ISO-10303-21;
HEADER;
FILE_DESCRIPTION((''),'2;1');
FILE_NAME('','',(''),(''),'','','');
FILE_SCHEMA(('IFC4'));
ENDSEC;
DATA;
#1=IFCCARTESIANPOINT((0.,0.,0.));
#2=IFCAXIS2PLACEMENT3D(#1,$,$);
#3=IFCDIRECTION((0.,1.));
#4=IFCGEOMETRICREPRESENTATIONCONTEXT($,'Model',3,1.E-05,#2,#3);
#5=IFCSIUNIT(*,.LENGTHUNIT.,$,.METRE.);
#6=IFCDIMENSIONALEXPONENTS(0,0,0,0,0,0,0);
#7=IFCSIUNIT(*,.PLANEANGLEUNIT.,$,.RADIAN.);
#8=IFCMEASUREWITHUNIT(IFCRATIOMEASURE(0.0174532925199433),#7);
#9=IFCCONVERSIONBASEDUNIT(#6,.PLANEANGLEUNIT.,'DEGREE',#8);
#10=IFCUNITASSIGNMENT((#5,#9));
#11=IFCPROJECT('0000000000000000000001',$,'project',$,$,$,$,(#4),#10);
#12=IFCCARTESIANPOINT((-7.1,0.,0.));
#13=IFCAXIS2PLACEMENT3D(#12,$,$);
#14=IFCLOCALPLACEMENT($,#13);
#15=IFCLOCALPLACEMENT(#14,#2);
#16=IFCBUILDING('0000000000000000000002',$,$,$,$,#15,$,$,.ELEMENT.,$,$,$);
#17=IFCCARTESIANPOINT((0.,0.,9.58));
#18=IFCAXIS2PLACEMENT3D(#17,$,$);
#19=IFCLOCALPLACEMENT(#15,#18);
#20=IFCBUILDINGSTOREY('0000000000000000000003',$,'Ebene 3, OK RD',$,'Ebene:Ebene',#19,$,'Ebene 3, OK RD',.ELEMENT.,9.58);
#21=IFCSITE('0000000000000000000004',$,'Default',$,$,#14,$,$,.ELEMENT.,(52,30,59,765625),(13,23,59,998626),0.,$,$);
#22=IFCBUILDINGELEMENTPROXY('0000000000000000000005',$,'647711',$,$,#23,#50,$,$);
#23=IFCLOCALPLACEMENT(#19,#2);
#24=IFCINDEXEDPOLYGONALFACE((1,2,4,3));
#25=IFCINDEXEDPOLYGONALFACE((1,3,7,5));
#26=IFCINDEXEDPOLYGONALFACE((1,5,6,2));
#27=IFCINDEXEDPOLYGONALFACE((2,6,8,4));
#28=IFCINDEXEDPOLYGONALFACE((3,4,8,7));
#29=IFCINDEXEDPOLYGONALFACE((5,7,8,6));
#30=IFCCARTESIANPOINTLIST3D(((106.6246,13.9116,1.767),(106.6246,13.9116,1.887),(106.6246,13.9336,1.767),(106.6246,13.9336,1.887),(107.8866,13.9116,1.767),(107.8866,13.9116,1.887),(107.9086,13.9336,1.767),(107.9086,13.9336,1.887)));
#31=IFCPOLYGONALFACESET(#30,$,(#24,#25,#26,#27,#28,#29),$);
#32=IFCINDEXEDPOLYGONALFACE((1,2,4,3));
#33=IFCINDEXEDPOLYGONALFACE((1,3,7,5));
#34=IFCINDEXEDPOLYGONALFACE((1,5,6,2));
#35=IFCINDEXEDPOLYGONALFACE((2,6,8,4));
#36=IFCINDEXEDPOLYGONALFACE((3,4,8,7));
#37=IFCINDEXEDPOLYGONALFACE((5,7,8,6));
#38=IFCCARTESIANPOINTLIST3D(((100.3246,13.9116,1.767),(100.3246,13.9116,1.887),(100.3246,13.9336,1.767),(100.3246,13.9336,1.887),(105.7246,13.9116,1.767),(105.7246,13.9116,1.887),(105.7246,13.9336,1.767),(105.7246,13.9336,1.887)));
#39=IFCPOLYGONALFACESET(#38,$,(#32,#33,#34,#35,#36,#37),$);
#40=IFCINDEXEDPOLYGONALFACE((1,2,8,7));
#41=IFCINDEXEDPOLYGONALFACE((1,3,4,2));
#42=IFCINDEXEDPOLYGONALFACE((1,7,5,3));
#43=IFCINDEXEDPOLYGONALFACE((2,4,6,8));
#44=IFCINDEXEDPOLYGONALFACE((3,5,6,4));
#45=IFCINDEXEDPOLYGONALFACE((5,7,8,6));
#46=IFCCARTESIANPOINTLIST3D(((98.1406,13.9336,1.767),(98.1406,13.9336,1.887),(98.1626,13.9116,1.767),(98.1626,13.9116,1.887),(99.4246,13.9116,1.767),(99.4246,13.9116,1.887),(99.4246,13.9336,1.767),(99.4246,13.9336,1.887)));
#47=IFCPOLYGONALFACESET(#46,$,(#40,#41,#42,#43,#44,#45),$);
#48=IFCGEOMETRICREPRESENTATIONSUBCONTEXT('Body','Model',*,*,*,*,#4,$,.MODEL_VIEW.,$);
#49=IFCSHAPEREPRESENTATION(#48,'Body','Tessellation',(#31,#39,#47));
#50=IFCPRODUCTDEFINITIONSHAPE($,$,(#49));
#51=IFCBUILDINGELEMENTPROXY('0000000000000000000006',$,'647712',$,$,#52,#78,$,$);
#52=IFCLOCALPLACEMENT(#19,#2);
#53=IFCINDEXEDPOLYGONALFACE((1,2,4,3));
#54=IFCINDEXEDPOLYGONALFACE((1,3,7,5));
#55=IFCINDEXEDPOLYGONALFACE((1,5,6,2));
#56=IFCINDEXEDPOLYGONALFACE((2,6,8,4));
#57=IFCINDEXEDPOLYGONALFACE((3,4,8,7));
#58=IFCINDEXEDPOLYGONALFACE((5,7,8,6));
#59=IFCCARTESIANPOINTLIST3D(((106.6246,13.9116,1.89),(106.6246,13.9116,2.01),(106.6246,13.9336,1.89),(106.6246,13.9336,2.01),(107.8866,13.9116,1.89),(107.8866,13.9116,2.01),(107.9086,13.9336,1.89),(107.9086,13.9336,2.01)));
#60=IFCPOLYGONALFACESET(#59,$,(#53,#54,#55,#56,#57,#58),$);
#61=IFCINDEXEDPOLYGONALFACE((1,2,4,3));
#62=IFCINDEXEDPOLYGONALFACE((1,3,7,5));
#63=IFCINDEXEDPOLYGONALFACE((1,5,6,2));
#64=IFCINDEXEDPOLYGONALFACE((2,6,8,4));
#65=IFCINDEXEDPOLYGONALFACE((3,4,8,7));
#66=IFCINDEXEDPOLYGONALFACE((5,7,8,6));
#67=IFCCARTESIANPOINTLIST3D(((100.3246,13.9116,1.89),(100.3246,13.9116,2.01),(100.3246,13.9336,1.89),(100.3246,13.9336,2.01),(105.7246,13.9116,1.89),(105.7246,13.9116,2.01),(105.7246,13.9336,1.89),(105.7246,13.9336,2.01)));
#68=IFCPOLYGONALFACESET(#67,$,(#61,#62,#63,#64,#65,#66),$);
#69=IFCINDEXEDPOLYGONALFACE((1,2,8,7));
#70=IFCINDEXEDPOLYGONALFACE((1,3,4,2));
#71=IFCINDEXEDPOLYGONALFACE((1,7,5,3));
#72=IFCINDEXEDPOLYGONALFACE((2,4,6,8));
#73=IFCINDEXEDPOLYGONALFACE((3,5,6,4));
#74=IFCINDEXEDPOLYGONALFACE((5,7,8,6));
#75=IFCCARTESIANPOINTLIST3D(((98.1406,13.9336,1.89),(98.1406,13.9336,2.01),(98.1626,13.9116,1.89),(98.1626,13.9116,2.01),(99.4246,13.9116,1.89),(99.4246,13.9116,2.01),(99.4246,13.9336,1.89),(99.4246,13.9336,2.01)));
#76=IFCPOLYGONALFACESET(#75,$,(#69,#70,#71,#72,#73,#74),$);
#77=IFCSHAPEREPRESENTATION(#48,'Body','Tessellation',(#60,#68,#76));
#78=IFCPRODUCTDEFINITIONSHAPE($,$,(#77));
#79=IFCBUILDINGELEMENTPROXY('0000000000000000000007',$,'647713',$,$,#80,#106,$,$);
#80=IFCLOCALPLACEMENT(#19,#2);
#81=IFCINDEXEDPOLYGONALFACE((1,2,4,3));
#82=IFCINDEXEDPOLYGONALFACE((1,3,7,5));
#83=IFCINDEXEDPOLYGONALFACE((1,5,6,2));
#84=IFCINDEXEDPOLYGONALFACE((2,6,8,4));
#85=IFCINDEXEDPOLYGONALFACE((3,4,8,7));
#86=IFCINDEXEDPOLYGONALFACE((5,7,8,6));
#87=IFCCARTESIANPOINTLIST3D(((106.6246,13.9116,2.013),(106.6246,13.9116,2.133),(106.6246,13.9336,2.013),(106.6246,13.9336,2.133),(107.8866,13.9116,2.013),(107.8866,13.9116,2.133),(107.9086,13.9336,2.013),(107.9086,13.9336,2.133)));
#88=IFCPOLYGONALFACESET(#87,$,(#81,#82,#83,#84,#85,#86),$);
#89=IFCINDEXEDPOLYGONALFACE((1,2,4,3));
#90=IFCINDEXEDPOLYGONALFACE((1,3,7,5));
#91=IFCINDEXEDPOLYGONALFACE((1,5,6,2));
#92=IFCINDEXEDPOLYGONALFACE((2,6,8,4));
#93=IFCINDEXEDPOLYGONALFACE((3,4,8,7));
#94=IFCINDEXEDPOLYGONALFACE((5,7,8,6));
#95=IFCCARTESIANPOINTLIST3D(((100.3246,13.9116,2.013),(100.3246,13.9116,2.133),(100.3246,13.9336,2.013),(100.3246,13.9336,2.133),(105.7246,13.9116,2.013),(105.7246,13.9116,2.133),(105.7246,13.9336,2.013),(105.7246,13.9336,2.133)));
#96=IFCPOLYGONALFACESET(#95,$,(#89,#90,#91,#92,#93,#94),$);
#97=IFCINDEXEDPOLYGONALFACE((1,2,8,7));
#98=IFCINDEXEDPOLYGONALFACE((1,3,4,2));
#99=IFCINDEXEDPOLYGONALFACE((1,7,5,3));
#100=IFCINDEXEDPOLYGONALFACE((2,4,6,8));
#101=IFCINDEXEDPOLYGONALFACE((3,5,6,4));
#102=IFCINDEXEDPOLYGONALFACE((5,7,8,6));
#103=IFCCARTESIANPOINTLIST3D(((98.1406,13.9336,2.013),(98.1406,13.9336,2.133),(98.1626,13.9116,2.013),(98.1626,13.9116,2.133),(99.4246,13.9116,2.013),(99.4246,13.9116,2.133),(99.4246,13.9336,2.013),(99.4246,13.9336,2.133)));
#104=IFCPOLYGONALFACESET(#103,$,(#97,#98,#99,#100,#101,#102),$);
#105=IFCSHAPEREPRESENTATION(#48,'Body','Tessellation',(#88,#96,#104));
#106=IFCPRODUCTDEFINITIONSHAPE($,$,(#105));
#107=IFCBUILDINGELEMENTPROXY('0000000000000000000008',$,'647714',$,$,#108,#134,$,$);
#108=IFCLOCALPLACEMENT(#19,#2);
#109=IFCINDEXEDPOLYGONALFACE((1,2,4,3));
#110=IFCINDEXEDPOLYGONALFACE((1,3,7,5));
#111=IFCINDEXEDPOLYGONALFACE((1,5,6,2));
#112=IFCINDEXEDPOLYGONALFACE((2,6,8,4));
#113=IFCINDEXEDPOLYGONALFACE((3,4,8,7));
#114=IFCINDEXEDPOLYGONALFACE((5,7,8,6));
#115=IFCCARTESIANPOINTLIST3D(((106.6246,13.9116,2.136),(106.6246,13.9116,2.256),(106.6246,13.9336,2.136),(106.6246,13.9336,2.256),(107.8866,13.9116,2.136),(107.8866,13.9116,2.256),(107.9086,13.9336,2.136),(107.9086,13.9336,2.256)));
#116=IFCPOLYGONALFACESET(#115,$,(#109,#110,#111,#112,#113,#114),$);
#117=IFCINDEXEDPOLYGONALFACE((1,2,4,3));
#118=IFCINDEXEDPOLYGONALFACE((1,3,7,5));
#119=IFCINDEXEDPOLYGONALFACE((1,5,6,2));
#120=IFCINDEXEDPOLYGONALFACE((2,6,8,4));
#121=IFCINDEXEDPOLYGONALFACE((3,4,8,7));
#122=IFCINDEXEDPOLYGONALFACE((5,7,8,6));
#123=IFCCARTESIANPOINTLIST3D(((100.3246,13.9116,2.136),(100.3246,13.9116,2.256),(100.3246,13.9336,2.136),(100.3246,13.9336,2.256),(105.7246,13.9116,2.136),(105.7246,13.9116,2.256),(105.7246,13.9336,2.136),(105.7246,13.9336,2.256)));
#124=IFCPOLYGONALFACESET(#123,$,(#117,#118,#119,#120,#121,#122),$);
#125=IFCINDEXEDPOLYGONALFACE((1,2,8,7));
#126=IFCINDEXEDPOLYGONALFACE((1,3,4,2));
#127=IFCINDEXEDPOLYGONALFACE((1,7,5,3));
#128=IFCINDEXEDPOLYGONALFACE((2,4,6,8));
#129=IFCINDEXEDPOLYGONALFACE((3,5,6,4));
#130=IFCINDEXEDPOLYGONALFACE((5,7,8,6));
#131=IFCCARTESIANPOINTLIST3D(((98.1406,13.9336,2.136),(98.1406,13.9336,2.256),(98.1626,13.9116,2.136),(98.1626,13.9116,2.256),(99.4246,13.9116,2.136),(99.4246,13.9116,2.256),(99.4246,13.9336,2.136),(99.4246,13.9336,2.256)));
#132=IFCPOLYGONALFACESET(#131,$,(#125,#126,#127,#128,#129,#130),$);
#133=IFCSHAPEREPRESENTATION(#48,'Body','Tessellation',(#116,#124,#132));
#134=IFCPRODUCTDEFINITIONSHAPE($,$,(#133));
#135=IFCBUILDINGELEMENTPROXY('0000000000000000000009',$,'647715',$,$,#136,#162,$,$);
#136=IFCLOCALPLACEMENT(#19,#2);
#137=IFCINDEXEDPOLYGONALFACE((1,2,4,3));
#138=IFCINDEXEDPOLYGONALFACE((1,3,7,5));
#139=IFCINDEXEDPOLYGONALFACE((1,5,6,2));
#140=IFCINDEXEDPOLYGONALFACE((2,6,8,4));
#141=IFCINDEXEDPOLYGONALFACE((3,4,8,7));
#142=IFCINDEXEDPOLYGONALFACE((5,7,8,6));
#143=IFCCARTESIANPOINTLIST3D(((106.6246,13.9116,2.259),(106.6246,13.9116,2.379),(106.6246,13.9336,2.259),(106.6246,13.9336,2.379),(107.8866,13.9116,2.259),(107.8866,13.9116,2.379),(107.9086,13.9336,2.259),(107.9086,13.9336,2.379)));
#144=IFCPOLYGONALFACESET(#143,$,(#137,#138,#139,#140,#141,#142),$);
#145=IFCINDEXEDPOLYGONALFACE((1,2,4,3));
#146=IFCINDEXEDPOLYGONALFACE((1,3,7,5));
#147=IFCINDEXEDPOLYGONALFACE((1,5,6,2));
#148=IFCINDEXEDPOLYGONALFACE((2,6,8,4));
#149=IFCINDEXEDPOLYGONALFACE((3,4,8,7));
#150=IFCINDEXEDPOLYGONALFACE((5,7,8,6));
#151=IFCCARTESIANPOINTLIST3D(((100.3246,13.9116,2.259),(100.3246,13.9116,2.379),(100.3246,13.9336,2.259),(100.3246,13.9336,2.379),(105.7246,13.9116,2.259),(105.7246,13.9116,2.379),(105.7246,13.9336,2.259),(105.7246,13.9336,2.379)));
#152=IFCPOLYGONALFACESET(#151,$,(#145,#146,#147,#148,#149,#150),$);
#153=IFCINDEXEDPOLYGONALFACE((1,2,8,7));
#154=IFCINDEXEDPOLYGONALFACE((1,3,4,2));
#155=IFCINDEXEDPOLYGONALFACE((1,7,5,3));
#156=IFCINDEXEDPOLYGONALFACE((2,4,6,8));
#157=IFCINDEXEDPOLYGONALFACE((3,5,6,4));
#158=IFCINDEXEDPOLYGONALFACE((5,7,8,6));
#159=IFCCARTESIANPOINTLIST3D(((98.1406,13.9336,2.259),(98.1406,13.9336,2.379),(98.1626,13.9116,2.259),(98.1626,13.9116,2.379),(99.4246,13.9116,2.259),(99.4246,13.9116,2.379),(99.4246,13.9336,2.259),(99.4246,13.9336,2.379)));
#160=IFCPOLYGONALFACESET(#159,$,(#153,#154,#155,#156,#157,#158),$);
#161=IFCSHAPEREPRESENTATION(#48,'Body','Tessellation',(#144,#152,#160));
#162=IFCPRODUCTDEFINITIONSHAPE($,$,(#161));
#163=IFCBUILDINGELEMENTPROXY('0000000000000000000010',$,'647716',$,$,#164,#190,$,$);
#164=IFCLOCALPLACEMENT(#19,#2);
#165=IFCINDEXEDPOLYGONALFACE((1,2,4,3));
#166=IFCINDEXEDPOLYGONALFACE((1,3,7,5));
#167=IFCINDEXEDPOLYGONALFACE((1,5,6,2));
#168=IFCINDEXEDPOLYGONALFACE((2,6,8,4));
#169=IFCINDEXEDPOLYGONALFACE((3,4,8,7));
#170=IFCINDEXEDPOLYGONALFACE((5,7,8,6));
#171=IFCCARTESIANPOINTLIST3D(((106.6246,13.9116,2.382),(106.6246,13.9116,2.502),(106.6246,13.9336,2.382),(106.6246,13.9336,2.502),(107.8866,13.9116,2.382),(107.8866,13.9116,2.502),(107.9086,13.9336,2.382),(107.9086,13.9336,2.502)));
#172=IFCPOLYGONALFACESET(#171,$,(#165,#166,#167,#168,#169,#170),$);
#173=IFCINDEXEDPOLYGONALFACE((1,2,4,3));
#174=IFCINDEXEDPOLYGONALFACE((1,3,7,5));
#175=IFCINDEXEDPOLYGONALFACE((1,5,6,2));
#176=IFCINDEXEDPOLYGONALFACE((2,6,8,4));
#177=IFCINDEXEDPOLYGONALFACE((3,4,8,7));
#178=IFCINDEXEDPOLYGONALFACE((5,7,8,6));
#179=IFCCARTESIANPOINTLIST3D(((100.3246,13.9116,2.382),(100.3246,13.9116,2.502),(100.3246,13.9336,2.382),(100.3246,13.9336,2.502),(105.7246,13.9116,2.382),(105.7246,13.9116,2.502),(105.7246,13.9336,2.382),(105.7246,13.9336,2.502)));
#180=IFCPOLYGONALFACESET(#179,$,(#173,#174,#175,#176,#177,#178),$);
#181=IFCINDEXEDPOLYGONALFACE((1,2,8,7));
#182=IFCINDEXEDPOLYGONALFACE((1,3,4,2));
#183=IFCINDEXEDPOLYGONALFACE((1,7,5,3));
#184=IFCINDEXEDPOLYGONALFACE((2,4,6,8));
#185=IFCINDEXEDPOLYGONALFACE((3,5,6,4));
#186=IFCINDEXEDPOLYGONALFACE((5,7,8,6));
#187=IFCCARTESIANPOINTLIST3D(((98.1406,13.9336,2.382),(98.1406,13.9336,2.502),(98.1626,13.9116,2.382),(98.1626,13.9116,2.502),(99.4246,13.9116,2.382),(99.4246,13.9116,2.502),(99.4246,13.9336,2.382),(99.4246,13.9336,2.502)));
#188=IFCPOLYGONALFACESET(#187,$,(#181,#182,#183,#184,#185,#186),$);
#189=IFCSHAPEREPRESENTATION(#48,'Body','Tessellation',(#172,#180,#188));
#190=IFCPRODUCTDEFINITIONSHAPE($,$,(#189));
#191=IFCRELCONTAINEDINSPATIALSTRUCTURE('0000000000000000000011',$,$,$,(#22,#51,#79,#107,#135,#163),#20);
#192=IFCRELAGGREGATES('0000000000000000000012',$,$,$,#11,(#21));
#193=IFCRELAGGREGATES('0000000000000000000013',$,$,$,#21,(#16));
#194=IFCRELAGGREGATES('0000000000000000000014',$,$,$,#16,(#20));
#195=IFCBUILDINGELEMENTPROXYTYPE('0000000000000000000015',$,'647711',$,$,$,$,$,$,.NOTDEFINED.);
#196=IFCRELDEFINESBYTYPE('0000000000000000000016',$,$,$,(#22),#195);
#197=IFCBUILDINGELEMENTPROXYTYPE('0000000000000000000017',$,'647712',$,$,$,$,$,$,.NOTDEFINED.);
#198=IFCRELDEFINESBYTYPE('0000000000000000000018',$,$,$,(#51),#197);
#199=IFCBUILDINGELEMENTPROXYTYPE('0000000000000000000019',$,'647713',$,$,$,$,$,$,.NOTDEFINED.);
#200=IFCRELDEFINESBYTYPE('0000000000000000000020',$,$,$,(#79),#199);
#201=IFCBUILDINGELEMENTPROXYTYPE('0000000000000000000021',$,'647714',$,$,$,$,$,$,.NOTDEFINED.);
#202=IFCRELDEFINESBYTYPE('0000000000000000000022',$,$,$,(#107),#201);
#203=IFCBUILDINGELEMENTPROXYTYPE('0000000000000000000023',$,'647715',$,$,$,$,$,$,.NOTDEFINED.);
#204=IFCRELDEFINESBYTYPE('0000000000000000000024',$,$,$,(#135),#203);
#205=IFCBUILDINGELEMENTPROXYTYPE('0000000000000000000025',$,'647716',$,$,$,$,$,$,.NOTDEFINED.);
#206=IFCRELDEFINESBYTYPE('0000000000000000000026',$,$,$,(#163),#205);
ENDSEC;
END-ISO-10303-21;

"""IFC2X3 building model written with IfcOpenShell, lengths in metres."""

from ifc_helpers import new_model, entity, si_unit, converted_unit, direction, frame, frame_2d, origin, place, context, subcontext, project, spatial, polyline, rectangle, outline, extrude, type_object, element, save


model = new_model("IFC2X3")

# Units and contexts
model_context = context("Model", 3, precision=1e-05, world=origin(), true_north=direction((0.0, 1.0)))
body_context = subcontext(model_context, "Body", "Model", "MODEL_VIEW")
ifc_project = project(units=[si_unit("LENGTHUNIT", "METRE"), converted_unit("PLANEANGLEUNIT", "DEGREE", entity("IfcRatioMeasure", 0.0174532925199433), si_unit("PLANEANGLEUNIT", "RADIAN"), dimensions=[0, 0, 0, 0, 0, 0, 0])], contexts=[model_context])

# Site, building, storey
site_placement = place(None, frame((-7.1, 0.0, 0.0)))
site = spatial("IfcSite", under=ifc_project, at=site_placement, Name="Default", CompositionType="ELEMENT", RefLatitude=(52, 30, 59, 765625), RefLongitude=(13, 23, 59, 998626), RefElevation=0.0)
building_placement = place(site_placement, origin())
building = spatial("IfcBuilding", under=site, at=building_placement, CompositionType="ELEMENT")
storey_placement = place(building_placement, frame((0.0, 0.0, 9.58)))
storey = spatial("IfcBuildingStorey", under=building, at=storey_placement, Name="Ebene 3, OK RD", ObjectType="Ebene:Ebene", LongName="Ebene 3, OK RD", CompositionType="ELEMENT", Elevation=9.58)

# Building element proxies
building_element_proxy_type_1 = type_object("IfcBuildingElementProxyType", Name="647711", PredefinedType="NOTDEFINED")
proxy_1_placement = place(storey_placement, origin())
element("IfcBuildingElementProxy", 1, at=proxy_1_placement, inside=storey, type_object=building_element_proxy_type_1, Name="647711", context=body_context, shape_type="SweptSolid", body=[
    extrude(outline(polyline([(-0.6365, -0.011), (0.6255, -0.011), (0.6475, 0.011), (-0.6365, 0.011), (-0.6365, -0.011)])), frame((107.2611, 13.9226, 1.767)), (0.0, 0.0, 1.0), 0.12),
    extrude(rectangle(XDim=5.4, YDim=0.022, at=frame_2d((0.0, 0.0), x_axis=(1.0, 0.0))), frame((103.0246, 13.9226, 1.767)), (0.0, 0.0, 1.0), 0.12),
    extrude(outline(polyline([(-0.6255, -0.011), (0.6365, -0.011), (0.6365, 0.011), (-0.6475, 0.011), (-0.6255, -0.011)])), frame((98.7881, 13.9226, 1.767)), (0.0, 0.0, 1.0), 0.12),
])
building_element_proxy_type_2 = type_object("IfcBuildingElementProxyType", Name="647712", PredefinedType="NOTDEFINED")
proxy_2_placement = place(storey_placement, origin())
element("IfcBuildingElementProxy", 2, at=proxy_2_placement, inside=storey, type_object=building_element_proxy_type_2, Name="647712", context=body_context, shape_type="SweptSolid", body=[
    extrude(outline(polyline([(-0.6365, -0.011), (0.6255, -0.011), (0.6475, 0.011), (-0.6365, 0.011), (-0.6365, -0.011)])), frame((107.2611, 13.9226, 1.89)), (0.0, 0.0, 1.0), 0.12),
    extrude(rectangle(XDim=5.4, YDim=0.022, at=frame_2d((0.0, 0.0), x_axis=(1.0, 0.0))), frame((103.0246, 13.9226, 1.89)), (0.0, 0.0, 1.0), 0.12),
    extrude(outline(polyline([(-0.6255, -0.011), (0.6365, -0.011), (0.6365, 0.011), (-0.6475, 0.011), (-0.6255, -0.011)])), frame((98.7881, 13.9226, 1.89)), (0.0, 0.0, 1.0), 0.12),
])
building_element_proxy_type_3 = type_object("IfcBuildingElementProxyType", Name="647713", PredefinedType="NOTDEFINED")
proxy_3_placement = place(storey_placement, origin())
element("IfcBuildingElementProxy", 3, at=proxy_3_placement, inside=storey, type_object=building_element_proxy_type_3, Name="647713", context=body_context, shape_type="SweptSolid", body=[
    extrude(outline(polyline([(-0.6365, -0.011), (0.6255, -0.011), (0.6475, 0.011), (-0.6365, 0.011), (-0.6365, -0.011)])), frame((107.2611, 13.9226, 2.013)), (0.0, 0.0, 1.0), 0.12),
    extrude(rectangle(XDim=5.4, YDim=0.022, at=frame_2d((0.0, 0.0), x_axis=(1.0, 0.0))), frame((103.0246, 13.9226, 2.013)), (0.0, 0.0, 1.0), 0.12),
    extrude(outline(polyline([(-0.6255, -0.011), (0.6365, -0.011), (0.6365, 0.011), (-0.6475, 0.011), (-0.6255, -0.011)])), frame((98.7881, 13.9226, 2.013)), (0.0, 0.0, 1.0), 0.12),
])
building_element_proxy_type_4 = type_object("IfcBuildingElementProxyType", Name="647714", PredefinedType="NOTDEFINED")
proxy_4_placement = place(storey_placement, origin())
element("IfcBuildingElementProxy", 4, at=proxy_4_placement, inside=storey, type_object=building_element_proxy_type_4, Name="647714", context=body_context, shape_type="SweptSolid", body=[
    extrude(outline(polyline([(-0.6365, -0.011), (0.6255, -0.011), (0.6475, 0.011), (-0.6365, 0.011), (-0.6365, -0.011)])), frame((107.2611, 13.9226, 2.136)), (0.0, 0.0, 1.0), 0.12),
    extrude(rectangle(XDim=5.4, YDim=0.022, at=frame_2d((0.0, 0.0), x_axis=(1.0, 0.0))), frame((103.0246, 13.9226, 2.136)), (0.0, 0.0, 1.0), 0.12),
    extrude(outline(polyline([(-0.6255, -0.011), (0.6365, -0.011), (0.6365, 0.011), (-0.6475, 0.011), (-0.6255, -0.011)])), frame((98.7881, 13.9226, 2.136)), (0.0, 0.0, 1.0), 0.12),
])
building_element_proxy_type_5 = type_object("IfcBuildingElementProxyType", Name="647715", PredefinedType="NOTDEFINED")
proxy_5_placement = place(storey_placement, origin())
element("IfcBuildingElementProxy", 5, at=proxy_5_placement, inside=storey, type_object=building_element_proxy_type_5, Name="647715", context=body_context, shape_type="SweptSolid", body=[
    extrude(outline(polyline([(-0.6365, -0.011), (0.6255, -0.011), (0.6475, 0.011), (-0.6365, 0.011), (-0.6365, -0.011)])), frame((107.2611, 13.9226, 2.259)), (0.0, 0.0, 1.0), 0.12),
    extrude(rectangle(XDim=5.4, YDim=0.022, at=frame_2d((0.0, 0.0), x_axis=(1.0, 0.0))), frame((103.0246, 13.9226, 2.259)), (0.0, 0.0, 1.0), 0.12),
    extrude(outline(polyline([(-0.6255, -0.011), (0.6365, -0.011), (0.6365, 0.011), (-0.6475, 0.011), (-0.6255, -0.011)])), frame((98.7881, 13.9226, 2.259)), (0.0, 0.0, 1.0), 0.12),
])
building_element_proxy_type_6 = type_object("IfcBuildingElementProxyType", Name="647716", PredefinedType="NOTDEFINED")
proxy_6_placement = place(storey_placement, origin())
element("IfcBuildingElementProxy", 6, at=proxy_6_placement, inside=storey, type_object=building_element_proxy_type_6, Name="647716", context=body_context, shape_type="SweptSolid", body=[
    extrude(outline(polyline([(-0.6365, -0.011), (0.6255, -0.011), (0.6475, 0.011), (-0.6365, 0.011), (-0.6365, -0.011)])), frame((107.2611, 13.9226, 2.382)), (0.0, 0.0, 1.0), 0.12),
    extrude(rectangle(XDim=5.4, YDim=0.022, at=frame_2d((0.0, 0.0), x_axis=(1.0, 0.0))), frame((103.0246, 13.9226, 2.382)), (0.0, 0.0, 1.0), 0.12),
    extrude(outline(polyline([(-0.6255, -0.011), (0.6365, -0.011), (0.6365, 0.011), (-0.6475, 0.011), (-0.6255, -0.011)])), frame((98.7881, 13.9226, 2.382)), (0.0, 0.0, 1.0), 0.12),
])

save(model, "model.ifc")
